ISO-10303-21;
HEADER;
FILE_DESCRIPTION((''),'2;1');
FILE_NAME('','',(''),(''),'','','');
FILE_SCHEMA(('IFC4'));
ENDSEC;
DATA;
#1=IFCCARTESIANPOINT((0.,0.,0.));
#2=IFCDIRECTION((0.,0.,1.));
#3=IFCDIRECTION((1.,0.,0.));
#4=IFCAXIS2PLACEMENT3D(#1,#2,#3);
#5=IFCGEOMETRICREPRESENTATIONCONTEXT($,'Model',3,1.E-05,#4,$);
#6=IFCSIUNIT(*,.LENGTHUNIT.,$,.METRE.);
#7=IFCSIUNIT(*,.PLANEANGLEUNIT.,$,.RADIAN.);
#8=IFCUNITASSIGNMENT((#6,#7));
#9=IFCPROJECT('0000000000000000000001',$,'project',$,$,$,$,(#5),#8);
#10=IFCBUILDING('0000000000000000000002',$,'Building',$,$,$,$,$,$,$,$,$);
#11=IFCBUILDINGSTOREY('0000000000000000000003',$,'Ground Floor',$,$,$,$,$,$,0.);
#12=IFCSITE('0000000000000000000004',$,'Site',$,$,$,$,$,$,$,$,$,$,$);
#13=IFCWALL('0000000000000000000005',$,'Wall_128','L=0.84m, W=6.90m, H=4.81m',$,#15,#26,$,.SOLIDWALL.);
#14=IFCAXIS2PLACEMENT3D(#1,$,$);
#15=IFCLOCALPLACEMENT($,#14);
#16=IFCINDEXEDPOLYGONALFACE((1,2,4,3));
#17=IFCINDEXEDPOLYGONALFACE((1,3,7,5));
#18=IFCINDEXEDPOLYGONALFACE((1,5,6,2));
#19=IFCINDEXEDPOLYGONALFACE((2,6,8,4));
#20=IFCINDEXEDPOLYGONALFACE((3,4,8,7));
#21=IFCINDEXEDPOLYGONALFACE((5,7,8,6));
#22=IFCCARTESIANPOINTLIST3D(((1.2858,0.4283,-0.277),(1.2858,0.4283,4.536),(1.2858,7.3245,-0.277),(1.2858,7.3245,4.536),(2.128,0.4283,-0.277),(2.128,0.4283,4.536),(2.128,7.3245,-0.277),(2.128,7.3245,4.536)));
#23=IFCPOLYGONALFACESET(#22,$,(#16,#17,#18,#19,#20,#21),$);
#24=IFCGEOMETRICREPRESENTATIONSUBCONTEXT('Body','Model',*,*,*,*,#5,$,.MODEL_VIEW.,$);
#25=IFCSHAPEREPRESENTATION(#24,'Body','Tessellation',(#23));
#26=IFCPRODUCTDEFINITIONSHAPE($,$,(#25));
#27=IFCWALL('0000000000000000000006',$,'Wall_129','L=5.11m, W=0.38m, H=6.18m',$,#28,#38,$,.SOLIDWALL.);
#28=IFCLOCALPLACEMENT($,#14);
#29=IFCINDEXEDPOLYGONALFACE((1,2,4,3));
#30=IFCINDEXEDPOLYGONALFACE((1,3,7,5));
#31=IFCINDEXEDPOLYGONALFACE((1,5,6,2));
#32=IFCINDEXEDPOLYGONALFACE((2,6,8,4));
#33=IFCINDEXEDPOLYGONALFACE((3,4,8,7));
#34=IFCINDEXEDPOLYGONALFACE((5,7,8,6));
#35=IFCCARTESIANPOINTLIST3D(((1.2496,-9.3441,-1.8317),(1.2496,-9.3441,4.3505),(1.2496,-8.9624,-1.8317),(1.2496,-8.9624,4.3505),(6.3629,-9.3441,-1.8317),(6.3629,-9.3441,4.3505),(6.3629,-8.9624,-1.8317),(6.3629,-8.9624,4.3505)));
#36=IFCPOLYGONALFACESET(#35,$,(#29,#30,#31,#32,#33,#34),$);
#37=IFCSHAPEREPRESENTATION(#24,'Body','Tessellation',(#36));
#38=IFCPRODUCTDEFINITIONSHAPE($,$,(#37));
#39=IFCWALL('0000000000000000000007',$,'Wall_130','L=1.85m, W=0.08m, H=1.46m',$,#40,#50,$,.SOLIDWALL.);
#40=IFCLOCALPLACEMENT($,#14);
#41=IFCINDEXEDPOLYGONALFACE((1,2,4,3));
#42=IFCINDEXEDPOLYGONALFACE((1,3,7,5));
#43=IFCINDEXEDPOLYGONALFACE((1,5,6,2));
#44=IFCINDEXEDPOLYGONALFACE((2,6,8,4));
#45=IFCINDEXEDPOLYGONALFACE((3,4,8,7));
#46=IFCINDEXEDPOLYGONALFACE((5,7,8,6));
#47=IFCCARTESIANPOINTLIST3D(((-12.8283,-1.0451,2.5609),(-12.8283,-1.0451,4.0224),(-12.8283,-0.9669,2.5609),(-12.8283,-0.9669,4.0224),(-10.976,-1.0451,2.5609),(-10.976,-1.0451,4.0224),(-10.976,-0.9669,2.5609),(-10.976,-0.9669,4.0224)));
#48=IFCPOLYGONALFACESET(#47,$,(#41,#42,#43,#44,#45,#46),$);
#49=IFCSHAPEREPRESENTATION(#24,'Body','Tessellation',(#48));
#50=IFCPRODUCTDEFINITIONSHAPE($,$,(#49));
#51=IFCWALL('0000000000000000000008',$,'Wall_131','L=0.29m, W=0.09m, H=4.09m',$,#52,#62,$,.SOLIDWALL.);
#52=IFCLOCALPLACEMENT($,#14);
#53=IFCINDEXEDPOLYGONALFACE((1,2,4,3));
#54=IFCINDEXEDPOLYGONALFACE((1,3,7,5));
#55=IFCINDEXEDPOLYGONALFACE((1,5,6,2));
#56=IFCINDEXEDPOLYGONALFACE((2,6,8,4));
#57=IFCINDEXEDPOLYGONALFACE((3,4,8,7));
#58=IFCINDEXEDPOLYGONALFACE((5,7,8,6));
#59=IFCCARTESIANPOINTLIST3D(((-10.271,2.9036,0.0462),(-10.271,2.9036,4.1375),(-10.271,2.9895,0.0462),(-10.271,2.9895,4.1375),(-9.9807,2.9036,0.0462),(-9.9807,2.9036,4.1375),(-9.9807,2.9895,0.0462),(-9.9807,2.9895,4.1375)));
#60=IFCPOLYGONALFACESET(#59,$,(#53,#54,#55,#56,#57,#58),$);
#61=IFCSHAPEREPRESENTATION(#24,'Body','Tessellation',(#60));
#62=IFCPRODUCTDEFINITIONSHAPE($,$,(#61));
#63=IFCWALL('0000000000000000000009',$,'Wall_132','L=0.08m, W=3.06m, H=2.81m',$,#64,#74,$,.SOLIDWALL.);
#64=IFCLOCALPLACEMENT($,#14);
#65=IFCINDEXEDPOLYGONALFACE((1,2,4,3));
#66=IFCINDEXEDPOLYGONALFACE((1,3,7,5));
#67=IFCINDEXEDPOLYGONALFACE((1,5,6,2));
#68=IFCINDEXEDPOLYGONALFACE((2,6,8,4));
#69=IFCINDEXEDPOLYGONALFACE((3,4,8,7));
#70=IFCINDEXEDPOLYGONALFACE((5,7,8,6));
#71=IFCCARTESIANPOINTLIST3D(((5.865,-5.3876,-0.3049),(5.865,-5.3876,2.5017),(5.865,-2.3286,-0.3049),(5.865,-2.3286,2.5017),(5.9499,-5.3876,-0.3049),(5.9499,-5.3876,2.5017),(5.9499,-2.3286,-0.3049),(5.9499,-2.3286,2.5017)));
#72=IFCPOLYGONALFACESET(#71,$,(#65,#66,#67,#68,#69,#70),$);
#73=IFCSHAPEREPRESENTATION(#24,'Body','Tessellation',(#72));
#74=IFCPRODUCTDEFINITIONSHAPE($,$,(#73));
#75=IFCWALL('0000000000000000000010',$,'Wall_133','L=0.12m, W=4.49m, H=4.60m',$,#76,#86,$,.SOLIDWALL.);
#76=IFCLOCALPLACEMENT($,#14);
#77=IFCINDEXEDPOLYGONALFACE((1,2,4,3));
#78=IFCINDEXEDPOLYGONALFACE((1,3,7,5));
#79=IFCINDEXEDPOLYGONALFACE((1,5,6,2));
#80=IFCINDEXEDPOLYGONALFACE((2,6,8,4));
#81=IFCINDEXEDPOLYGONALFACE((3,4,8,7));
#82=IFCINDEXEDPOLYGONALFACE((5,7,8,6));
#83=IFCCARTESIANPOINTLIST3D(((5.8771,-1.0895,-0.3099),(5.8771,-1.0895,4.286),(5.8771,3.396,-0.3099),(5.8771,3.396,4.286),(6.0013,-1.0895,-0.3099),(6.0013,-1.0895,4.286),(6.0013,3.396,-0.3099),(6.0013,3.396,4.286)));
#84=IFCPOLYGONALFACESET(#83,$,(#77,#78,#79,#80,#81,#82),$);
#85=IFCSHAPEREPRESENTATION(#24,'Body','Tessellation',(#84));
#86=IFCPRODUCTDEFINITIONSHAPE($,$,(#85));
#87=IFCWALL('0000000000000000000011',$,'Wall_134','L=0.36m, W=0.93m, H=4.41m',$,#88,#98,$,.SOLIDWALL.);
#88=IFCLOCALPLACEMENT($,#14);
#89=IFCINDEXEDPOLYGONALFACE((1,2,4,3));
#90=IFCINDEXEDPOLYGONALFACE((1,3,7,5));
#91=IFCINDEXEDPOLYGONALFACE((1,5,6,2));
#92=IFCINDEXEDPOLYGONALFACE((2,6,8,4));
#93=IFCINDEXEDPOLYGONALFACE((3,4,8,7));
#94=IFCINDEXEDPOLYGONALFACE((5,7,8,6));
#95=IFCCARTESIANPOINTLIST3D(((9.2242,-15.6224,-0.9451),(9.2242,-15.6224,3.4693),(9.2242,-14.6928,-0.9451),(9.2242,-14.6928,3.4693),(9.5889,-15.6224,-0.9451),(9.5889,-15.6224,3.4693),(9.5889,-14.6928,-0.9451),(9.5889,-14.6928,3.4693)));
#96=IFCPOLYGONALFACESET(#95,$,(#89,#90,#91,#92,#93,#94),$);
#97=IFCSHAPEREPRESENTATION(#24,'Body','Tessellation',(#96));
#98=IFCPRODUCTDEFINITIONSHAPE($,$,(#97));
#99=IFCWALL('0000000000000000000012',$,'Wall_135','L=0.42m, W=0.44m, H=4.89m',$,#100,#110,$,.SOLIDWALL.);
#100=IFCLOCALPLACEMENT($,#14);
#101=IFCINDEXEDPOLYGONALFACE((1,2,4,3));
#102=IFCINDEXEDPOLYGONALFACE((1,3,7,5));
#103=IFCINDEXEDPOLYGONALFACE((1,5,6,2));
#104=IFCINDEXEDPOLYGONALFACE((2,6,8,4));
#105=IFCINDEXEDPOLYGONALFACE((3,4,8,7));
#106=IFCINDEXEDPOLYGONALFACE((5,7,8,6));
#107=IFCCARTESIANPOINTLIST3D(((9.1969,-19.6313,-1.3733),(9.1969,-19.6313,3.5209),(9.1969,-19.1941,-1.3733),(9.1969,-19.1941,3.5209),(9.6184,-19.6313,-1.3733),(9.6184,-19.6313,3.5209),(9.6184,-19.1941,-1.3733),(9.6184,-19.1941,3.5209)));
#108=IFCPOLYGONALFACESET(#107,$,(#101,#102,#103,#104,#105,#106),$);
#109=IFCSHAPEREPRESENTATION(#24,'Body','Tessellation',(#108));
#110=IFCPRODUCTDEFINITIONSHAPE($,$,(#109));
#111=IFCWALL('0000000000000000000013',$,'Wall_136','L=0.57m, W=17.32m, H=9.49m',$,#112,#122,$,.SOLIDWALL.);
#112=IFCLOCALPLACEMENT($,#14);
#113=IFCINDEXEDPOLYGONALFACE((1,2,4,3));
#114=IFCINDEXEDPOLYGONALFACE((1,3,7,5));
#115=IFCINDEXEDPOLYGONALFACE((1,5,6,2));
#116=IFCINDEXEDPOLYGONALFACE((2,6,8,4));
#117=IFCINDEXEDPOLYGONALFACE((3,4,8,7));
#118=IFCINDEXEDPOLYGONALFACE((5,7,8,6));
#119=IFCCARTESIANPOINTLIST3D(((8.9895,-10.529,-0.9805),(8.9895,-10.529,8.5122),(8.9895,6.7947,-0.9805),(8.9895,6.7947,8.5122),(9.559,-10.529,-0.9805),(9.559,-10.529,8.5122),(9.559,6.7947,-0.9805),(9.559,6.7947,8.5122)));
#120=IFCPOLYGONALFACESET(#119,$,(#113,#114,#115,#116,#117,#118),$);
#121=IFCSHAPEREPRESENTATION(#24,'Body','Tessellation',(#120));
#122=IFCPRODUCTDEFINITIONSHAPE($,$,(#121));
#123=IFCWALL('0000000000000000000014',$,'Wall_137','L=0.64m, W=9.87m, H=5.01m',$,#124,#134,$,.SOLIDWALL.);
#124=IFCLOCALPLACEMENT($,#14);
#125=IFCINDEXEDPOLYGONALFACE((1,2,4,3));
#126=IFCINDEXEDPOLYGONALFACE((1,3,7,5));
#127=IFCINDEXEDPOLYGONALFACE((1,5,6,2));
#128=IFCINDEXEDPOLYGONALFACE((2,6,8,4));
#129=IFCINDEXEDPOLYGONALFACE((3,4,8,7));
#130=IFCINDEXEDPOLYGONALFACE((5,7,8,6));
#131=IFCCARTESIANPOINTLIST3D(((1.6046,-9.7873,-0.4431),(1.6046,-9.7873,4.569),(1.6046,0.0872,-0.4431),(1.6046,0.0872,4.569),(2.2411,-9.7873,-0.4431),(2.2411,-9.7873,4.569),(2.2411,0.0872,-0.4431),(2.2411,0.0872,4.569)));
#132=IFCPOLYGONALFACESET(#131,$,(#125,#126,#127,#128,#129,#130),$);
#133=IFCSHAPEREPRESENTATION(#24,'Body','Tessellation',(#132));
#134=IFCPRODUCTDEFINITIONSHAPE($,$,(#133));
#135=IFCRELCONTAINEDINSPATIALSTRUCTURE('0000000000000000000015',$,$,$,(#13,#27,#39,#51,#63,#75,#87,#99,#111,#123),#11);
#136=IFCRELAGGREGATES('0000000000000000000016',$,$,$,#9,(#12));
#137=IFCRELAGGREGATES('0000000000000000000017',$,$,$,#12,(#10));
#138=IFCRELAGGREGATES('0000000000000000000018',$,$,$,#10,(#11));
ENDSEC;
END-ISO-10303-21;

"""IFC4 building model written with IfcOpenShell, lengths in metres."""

from ifc_helpers import new_model, si_unit, frame, origin_with_axes, origin_2d, context, subcontext, project, spatial, rectangle, extrude, element, save


model = new_model("IFC4")

# Units and contexts
model_context = context("Model", 3, precision=1e-05, world=origin_with_axes())
body_context = subcontext(model_context, "Body", "Model", "MODEL_VIEW")
ifc_project = project(units=[si_unit("LENGTHUNIT", "METRE"), si_unit("PLANEANGLEUNIT", "RADIAN")], contexts=[model_context])

# Site, building, storey
site = spatial("IfcSite", under=ifc_project, Name="Site")
building = spatial("IfcBuilding", under=site, Name="Building")
storey = spatial("IfcBuildingStorey", under=building, Name="Ground Floor", Elevation=0.0)

# Walls
element("IfcWall", 1, inside=storey, Name="Wall_128", Description="L=0.84m, W=6.90m, H=4.81m", PredefinedType="SOLIDWALL", context=body_context, shape_type="SweptSolid", body=[
    extrude(rectangle(XDim=0.8422, YDim=6.8962, at=origin_2d()), frame((1.7069, 3.8764, -0.277), z_axis=(0.0, 0.0, 1.0), x_axis=(1.0, 0.0, 0.0)), (0.0, 0.0, 1.0), 4.8129),
])
element("IfcWall", 2, inside=storey, Name="Wall_129", Description="L=5.11m, W=0.38m, H=6.18m", PredefinedType="SOLIDWALL", context=body_context, shape_type="SweptSolid", body=[
    extrude(rectangle(XDim=5.1133, YDim=0.3817, at=origin_2d()), frame((3.8063, -9.1532, -1.8317), z_axis=(0.0, 0.0, 1.0), x_axis=(1.0, 0.0, 0.0)), (0.0, 0.0, 1.0), 6.1822),
])
element("IfcWall", 3, inside=storey, Name="Wall_130", Description="L=1.85m, W=0.08m, H=1.46m", PredefinedType="SOLIDWALL", context=body_context, shape_type="SweptSolid", body=[
    extrude(rectangle(XDim=1.8523, YDim=0.0783, at=origin_2d()), frame((-11.9021, -1.006, 2.5609), z_axis=(0.0, 0.0, 1.0), x_axis=(1.0, 0.0, 0.0)), (0.0, 0.0, 1.0), 1.4615),
])
element("IfcWall", 4, inside=storey, Name="Wall_131", Description="L=0.29m, W=0.09m, H=4.09m", PredefinedType="SOLIDWALL", context=body_context, shape_type="SweptSolid", body=[
    extrude(rectangle(XDim=0.2903, YDim=0.0859, at=origin_2d()), frame((-10.1258, 2.9466, 0.0462), z_axis=(0.0, 0.0, 1.0), x_axis=(1.0, 0.0, 0.0)), (0.0, 0.0, 1.0), 4.0912),
])
element("IfcWall", 5, inside=storey, Name="Wall_132", Description="L=0.08m, W=3.06m, H=2.81m", PredefinedType="SOLIDWALL", context=body_context, shape_type="SweptSolid", body=[
    extrude(rectangle(XDim=0.0849, YDim=3.059, at=origin_2d()), frame((5.9074, -3.8581, -0.3049), z_axis=(0.0, 0.0, 1.0), x_axis=(1.0, 0.0, 0.0)), (0.0, 0.0, 1.0), 2.8066),
])
element("IfcWall", 6, inside=storey, Name="Wall_133", Description="L=0.12m, W=4.49m, H=4.60m", PredefinedType="SOLIDWALL", context=body_context, shape_type="SweptSolid", body=[
    extrude(rectangle(XDim=0.1242, YDim=4.4854, at=origin_2d()), frame((5.9392, 1.1533, -0.3099), z_axis=(0.0, 0.0, 1.0), x_axis=(1.0, 0.0, 0.0)), (0.0, 0.0, 1.0), 4.5959),
])
element("IfcWall", 7, inside=storey, Name="Wall_134", Description="L=0.36m, W=0.93m, H=4.41m", PredefinedType="SOLIDWALL", context=body_context, shape_type="SweptSolid", body=[
    extrude(rectangle(XDim=0.3647, YDim=0.9296, at=origin_2d()), frame((9.4065, -15.1576, -0.9451), z_axis=(0.0, 0.0, 1.0), x_axis=(1.0, 0.0, 0.0)), (0.0, 0.0, 1.0), 4.4145),
])
element("IfcWall", 8, inside=storey, Name="Wall_135", Description="L=0.42m, W=0.44m, H=4.89m", PredefinedType="SOLIDWALL", context=body_context, shape_type="SweptSolid", body=[
    extrude(rectangle(XDim=0.4215, YDim=0.4372, at=origin_2d()), frame((9.4076, -19.4127, -1.3733), z_axis=(0.0, 0.0, 1.0), x_axis=(1.0, 0.0, 0.0)), (0.0, 0.0, 1.0), 4.8942),
])
element("IfcWall", 9, inside=storey, Name="Wall_136", Description="L=0.57m, W=17.32m, H=9.49m", PredefinedType="SOLIDWALL", context=body_context, shape_type="SweptSolid", body=[
    extrude(rectangle(XDim=0.5695, YDim=17.3237, at=origin_2d()), frame((9.2742, -1.8671, -0.9805), z_axis=(0.0, 0.0, 1.0), x_axis=(1.0, 0.0, 0.0)), (0.0, 0.0, 1.0), 9.4927),
])
element("IfcWall", 10, inside=storey, Name="Wall_137", Description="L=0.64m, W=9.87m, H=5.01m", PredefinedType="SOLIDWALL", context=body_context, shape_type="SweptSolid", body=[
    extrude(rectangle(XDim=0.6365, YDim=9.8745, at=origin_2d()), frame((1.9229, -4.8501, -0.4431), z_axis=(0.0, 0.0, 1.0), x_axis=(1.0, 0.0, 0.0)), (0.0, 0.0, 1.0), 5.0121),
])

save(model, "model.ifc")
